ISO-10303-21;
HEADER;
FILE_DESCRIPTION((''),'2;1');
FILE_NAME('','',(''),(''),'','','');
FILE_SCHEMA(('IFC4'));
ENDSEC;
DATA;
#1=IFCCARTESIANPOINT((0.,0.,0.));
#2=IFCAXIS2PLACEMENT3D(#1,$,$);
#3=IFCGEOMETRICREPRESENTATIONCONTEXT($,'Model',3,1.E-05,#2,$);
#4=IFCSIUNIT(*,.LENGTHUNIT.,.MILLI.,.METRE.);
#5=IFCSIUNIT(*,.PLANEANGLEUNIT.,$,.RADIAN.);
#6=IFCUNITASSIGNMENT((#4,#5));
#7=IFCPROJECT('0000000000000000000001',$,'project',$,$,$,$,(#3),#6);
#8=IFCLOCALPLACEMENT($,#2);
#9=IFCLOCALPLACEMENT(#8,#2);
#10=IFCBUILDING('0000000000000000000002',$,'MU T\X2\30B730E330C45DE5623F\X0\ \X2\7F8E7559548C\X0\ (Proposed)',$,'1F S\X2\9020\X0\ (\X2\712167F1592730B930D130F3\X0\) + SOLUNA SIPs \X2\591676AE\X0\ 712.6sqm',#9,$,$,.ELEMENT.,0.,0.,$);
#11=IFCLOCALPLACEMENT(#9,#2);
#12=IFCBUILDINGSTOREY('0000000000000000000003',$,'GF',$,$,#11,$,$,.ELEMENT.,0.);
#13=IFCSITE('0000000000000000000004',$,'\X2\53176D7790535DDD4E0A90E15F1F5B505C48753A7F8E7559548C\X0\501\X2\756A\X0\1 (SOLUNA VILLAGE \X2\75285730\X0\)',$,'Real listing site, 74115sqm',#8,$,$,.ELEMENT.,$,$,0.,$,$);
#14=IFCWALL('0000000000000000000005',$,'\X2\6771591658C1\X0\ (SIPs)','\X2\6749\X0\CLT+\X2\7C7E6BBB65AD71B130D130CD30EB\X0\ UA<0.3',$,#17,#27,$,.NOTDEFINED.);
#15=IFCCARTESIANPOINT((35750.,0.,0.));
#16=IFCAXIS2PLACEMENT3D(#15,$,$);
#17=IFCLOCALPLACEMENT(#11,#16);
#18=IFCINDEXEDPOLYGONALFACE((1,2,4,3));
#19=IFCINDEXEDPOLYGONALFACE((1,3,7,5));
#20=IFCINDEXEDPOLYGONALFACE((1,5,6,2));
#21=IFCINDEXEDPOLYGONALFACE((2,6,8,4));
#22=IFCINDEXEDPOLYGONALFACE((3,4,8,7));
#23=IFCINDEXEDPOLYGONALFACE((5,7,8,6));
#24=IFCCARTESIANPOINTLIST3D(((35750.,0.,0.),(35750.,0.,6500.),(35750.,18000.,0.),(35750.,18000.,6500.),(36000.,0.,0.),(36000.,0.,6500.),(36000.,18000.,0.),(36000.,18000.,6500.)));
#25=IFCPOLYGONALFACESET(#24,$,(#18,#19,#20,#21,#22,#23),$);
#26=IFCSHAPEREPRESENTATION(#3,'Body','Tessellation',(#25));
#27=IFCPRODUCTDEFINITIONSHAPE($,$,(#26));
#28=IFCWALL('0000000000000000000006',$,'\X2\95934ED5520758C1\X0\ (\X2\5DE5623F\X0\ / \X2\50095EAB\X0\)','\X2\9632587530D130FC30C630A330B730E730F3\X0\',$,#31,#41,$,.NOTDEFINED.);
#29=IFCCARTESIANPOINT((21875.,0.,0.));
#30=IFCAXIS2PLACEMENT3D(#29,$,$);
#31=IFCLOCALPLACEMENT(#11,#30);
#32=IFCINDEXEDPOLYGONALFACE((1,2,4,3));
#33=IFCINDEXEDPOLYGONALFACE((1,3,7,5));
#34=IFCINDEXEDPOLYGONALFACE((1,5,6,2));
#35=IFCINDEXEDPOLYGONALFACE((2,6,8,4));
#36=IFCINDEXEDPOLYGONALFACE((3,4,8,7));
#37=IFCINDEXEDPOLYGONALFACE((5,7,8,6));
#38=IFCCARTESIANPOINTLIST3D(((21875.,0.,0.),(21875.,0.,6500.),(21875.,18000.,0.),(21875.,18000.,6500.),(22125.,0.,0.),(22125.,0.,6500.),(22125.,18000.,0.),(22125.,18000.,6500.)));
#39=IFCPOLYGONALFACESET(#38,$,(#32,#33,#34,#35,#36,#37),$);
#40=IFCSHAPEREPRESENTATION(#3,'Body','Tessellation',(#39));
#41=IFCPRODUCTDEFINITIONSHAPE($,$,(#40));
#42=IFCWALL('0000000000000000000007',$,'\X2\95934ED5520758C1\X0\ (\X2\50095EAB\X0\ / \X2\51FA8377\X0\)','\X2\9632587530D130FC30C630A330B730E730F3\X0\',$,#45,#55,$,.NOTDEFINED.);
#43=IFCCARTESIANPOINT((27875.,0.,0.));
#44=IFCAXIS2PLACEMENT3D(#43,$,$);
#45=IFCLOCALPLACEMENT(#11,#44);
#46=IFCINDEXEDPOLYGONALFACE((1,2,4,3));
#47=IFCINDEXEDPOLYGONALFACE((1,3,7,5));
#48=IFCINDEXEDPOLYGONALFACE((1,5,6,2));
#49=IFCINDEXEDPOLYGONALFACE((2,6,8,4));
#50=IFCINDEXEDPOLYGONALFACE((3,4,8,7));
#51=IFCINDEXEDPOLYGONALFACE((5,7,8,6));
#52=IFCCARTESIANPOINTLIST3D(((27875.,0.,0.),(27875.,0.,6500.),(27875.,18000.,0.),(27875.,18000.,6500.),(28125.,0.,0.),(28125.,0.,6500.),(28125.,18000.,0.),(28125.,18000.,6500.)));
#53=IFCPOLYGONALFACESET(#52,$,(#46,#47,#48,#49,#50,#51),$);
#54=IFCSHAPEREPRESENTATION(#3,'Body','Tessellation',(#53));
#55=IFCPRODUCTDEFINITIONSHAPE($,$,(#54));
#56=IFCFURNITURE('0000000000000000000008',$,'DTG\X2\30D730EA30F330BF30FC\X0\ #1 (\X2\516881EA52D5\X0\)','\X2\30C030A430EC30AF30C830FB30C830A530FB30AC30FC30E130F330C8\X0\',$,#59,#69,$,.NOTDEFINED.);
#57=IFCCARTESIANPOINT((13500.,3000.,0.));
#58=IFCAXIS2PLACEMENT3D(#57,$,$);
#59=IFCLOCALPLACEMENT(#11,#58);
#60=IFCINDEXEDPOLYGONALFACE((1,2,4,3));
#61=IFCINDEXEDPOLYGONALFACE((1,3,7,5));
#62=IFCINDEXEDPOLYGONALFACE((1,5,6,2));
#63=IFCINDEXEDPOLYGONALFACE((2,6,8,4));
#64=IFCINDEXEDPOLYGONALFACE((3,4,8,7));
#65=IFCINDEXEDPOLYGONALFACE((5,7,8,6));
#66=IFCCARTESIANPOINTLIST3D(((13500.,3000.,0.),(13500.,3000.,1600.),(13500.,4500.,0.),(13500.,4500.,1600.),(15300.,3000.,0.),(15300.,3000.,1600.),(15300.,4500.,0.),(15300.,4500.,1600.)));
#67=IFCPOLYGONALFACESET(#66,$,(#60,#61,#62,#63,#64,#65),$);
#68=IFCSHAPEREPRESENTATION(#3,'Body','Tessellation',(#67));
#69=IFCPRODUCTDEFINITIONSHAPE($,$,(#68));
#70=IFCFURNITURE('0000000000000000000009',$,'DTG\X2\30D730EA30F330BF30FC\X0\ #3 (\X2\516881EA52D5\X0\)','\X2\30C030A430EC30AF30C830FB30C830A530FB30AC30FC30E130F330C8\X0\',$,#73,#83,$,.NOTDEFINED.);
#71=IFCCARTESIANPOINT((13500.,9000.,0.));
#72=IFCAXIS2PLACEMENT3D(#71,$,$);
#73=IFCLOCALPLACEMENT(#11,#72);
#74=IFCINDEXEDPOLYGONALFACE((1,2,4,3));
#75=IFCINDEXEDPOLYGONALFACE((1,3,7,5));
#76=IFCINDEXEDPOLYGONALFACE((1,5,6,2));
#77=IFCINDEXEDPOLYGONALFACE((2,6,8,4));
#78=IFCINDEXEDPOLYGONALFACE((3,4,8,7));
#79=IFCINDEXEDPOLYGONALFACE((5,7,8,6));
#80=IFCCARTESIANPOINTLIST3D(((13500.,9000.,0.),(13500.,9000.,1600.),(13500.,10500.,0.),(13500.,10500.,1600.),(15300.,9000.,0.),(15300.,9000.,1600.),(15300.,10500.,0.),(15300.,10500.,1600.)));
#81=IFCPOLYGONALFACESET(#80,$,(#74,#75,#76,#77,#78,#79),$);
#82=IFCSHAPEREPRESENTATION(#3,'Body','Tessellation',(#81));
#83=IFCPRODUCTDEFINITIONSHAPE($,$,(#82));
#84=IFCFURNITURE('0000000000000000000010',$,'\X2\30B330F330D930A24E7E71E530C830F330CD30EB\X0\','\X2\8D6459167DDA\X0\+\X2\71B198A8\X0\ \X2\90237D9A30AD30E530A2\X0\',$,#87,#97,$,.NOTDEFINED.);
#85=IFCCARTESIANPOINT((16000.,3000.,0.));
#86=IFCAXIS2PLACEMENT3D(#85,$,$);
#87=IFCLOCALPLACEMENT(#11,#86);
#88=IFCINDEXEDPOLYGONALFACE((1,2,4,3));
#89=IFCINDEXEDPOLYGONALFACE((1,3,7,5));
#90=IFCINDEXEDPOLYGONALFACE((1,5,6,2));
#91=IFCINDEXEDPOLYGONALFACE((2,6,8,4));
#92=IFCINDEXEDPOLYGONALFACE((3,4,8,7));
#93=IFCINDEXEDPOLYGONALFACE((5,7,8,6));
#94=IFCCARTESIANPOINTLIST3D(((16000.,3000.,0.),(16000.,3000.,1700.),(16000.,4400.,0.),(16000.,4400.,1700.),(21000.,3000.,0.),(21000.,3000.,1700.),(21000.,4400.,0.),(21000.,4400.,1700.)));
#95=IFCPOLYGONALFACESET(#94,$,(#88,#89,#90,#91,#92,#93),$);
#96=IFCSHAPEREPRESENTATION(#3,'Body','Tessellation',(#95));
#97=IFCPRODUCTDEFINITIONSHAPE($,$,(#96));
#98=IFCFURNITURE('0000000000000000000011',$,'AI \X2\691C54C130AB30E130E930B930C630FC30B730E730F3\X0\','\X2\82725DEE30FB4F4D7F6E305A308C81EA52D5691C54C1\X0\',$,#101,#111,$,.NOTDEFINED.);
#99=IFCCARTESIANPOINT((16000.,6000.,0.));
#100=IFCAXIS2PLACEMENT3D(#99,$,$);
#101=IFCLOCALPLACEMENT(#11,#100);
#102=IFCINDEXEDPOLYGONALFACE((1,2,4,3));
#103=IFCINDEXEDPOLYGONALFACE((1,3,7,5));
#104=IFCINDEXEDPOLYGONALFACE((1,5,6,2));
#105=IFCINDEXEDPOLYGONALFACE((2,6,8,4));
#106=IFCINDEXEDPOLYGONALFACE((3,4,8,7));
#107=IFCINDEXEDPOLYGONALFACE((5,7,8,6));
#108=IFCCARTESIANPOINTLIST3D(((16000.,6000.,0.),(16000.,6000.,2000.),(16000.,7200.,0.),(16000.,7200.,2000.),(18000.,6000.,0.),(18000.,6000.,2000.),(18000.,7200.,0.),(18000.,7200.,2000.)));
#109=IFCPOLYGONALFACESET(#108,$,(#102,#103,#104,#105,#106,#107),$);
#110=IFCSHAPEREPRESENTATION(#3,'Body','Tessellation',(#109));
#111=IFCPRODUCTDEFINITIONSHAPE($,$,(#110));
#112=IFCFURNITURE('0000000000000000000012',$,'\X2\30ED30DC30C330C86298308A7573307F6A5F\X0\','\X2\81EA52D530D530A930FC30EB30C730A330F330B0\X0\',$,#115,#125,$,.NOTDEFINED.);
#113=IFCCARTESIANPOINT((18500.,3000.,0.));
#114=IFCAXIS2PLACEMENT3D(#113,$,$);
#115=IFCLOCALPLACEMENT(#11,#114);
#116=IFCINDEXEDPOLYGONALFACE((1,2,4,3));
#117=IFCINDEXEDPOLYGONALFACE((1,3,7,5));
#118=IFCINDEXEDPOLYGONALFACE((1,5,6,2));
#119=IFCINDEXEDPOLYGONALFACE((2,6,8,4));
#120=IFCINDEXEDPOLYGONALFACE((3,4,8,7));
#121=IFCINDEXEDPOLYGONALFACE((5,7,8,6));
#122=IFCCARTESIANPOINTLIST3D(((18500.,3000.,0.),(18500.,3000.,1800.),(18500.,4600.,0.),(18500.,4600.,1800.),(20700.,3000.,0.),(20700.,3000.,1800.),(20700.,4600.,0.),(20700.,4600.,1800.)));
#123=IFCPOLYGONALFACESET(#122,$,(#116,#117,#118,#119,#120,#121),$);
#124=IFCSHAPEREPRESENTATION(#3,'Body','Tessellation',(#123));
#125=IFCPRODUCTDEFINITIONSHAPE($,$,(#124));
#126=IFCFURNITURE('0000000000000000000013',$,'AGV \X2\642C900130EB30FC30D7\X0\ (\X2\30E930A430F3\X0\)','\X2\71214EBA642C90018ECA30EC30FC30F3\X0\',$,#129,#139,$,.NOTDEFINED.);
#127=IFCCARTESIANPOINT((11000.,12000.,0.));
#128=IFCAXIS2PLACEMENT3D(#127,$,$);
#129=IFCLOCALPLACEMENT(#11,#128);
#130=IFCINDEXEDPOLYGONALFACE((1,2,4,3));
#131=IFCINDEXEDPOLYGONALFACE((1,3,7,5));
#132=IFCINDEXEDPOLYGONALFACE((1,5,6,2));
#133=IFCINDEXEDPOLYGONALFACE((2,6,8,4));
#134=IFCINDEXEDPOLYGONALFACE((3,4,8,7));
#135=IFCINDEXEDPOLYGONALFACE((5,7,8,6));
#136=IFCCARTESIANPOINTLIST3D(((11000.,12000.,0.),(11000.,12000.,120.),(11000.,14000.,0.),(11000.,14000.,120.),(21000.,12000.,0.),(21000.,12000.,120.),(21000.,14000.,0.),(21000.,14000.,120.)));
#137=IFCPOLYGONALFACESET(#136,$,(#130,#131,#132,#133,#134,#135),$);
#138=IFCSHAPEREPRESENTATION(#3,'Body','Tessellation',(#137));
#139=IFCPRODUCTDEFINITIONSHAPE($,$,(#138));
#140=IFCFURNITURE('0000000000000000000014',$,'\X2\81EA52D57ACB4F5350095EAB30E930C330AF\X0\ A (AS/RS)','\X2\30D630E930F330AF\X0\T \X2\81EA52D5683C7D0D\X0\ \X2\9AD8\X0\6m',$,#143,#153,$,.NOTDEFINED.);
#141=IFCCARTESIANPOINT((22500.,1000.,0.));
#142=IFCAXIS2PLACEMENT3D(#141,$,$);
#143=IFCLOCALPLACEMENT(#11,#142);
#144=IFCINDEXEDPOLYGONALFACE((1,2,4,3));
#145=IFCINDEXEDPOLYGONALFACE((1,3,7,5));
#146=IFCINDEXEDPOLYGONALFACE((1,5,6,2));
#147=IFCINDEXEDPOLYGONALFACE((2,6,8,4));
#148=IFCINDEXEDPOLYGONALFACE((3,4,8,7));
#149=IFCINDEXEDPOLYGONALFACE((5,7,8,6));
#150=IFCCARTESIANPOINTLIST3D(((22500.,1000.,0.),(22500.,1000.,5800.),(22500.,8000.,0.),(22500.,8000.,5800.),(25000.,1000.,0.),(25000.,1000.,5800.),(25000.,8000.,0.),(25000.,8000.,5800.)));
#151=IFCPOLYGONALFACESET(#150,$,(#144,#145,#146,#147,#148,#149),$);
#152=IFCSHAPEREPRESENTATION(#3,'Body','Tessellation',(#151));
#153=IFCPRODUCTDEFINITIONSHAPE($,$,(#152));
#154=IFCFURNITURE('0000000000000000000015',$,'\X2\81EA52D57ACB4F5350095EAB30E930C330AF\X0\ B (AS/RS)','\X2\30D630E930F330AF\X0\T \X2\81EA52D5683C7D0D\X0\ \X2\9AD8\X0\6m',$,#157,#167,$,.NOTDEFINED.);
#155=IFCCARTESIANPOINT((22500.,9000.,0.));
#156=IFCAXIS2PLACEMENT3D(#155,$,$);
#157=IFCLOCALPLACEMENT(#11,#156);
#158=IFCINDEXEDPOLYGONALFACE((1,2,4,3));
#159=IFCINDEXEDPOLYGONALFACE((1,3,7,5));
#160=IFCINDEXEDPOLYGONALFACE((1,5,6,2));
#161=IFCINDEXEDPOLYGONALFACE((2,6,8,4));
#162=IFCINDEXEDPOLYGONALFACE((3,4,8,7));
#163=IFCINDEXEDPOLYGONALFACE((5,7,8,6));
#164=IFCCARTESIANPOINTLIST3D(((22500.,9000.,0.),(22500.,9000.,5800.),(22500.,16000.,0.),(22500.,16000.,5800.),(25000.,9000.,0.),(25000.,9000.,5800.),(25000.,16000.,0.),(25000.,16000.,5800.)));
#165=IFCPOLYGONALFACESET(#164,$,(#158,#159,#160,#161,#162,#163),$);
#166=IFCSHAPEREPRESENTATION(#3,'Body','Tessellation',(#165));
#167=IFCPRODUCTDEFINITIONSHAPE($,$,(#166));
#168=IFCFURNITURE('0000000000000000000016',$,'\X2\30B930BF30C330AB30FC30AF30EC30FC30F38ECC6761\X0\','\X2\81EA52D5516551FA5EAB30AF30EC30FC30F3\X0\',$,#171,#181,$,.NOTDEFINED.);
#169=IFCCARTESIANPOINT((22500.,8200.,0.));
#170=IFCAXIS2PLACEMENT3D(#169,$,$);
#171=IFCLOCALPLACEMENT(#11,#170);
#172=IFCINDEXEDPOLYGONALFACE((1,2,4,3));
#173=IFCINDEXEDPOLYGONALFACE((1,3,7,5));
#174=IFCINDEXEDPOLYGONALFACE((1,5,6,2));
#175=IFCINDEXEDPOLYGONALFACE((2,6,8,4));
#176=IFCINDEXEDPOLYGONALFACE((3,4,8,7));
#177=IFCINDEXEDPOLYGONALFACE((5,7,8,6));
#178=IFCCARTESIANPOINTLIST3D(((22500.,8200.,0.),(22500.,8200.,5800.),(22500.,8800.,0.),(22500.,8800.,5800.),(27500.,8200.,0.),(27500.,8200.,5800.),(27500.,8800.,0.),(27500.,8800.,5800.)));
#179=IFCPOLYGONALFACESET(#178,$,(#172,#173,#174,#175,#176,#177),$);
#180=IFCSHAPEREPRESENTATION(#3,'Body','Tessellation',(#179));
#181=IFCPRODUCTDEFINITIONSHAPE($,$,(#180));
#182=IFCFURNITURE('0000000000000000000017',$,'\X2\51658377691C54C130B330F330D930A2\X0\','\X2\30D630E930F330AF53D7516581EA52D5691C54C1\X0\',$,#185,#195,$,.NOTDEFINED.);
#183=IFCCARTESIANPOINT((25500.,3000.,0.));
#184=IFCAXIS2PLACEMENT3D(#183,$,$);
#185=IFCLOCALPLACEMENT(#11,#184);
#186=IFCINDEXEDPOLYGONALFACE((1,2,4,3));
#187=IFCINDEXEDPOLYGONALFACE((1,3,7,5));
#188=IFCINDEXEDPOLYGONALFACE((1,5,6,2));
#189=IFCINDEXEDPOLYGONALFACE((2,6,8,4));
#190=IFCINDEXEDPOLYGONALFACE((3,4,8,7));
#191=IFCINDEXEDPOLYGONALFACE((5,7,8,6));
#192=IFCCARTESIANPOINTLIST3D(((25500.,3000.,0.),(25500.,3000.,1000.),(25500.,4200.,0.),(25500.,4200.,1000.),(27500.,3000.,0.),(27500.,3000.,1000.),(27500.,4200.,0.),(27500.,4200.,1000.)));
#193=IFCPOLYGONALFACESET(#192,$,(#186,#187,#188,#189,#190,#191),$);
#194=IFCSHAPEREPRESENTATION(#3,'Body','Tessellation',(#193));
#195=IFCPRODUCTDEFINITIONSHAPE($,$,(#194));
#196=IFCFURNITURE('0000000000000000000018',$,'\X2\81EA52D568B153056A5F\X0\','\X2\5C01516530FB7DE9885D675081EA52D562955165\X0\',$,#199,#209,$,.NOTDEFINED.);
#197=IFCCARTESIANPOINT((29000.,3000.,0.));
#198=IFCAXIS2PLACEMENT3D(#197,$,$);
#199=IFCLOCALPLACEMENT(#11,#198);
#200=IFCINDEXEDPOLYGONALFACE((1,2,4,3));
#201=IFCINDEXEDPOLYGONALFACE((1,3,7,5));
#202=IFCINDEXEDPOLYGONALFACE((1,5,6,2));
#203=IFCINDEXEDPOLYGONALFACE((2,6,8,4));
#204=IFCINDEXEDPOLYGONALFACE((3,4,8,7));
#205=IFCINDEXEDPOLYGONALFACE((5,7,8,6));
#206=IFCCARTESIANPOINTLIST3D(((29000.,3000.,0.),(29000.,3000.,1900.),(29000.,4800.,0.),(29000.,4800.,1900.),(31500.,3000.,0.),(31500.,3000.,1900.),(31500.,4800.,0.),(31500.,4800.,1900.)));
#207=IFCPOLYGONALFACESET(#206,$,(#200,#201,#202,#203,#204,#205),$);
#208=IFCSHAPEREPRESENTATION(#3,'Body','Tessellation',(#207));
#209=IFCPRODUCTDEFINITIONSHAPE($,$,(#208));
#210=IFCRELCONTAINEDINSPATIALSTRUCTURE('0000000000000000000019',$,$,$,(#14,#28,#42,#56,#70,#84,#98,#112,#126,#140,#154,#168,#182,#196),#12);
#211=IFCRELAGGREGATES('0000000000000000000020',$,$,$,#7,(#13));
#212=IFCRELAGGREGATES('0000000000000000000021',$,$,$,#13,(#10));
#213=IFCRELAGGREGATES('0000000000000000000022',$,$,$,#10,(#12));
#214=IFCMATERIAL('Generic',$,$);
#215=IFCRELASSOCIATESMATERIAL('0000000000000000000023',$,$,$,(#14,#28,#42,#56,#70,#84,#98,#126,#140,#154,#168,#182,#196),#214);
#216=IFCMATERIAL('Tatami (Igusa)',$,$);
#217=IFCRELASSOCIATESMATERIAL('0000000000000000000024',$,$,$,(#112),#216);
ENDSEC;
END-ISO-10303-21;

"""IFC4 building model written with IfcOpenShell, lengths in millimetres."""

from ifc_helpers import new_model, si_unit, frame, frame_2d, origin, place, context, project, spatial, rectangle, extrude, material, element, save


model = new_model("IFC4")

# Units and contexts
model_context = context("Model", 3, precision=1e-05, world=origin())
ifc_project = project(units=[si_unit("LENGTHUNIT", "METRE", prefix="MILLI"), si_unit("PLANEANGLEUNIT", "RADIAN")], contexts=[model_context])

# Site, building, storey
site_placement = place(None, origin())
site = spatial("IfcSite", under=ifc_project, at=site_placement, Name="北海道川上郡弟子屈町美留和501番1 (SOLUNA VILLAGE 用地)", ObjectType="Real listing site, 74115sqm", CompositionType="ELEMENT", RefElevation=0.0)
building_placement = place(site_placement, origin())
building = spatial("IfcBuilding", under=site, at=building_placement, Name="MU Tシャツ工房 美留和 (Proposed)", ObjectType="1F S造 (無柱大スパン) + SOLUNA SIPs 外皮 712.6sqm", CompositionType="ELEMENT", ElevationOfRefHeight=0.0, ElevationOfTerrain=0.0)
storey_placement = place(building_placement, origin())
storey = spatial("IfcBuildingStorey", under=building, at=storey_placement, Name="GF", CompositionType="ELEMENT", Elevation=0.0)

# Shared definitions
ifc_material_1 = material(Name="Generic")

# Walls
wall_1_placement = place(storey_placement, frame((35750.0, 0.0, 0.0)))
element("IfcWall", 1, at=wall_1_placement, inside=storey, material=ifc_material_1, Name="東外壁 (SIPs)", Description="杉CLT+籾殻断熱パネル UA<0.3", PredefinedType="NOTDEFINED", context=model_context, shape_type="SweptSolid", body=[
    extrude(rectangle(XDim=250.0, YDim=18000.0, at=frame_2d((125.0, 9000.0))), frame((35750.0, 0.0, 0.0)), (0.0, 0.0, 1.0), 6500.0),
])
wall_2_placement = place(storey_placement, frame((21875.0, 0.0, 0.0)))
element("IfcWall", 2, at=wall_2_placement, inside=storey, material=ifc_material_1, Name="間仕切壁 (工房 / 倉庫)", Description="防塵パーティション", PredefinedType="NOTDEFINED", context=model_context, shape_type="SweptSolid", body=[
    extrude(rectangle(XDim=250.0, YDim=18000.0, at=frame_2d((125.0, 9000.0))), frame((21875.0, 0.0, 0.0)), (0.0, 0.0, 1.0), 6500.0),
])
wall_3_placement = place(storey_placement, frame((27875.0, 0.0, 0.0)))
element("IfcWall", 3, at=wall_3_placement, inside=storey, material=ifc_material_1, Name="間仕切壁 (倉庫 / 出荷)", Description="防塵パーティション", PredefinedType="NOTDEFINED", context=model_context, shape_type="SweptSolid", body=[
    extrude(rectangle(XDim=250.0, YDim=18000.0, at=frame_2d((125.0, 9000.0))), frame((27875.0, 0.0, 0.0)), (0.0, 0.0, 1.0), 6500.0),
])

# Furniture
furniture_1_placement = place(storey_placement, frame((13500.0, 3000.0, 0.0)))
element("IfcFurniture", 4, at=furniture_1_placement, inside=storey, material=ifc_material_1, Name="DTGプリンター #1 (全自動)", Description="ダイレクト・トゥ・ガーメント", PredefinedType="NOTDEFINED", context=model_context, shape_type="SweptSolid", body=[
    extrude(rectangle(XDim=1800.0, YDim=1500.0, at=frame_2d((900.0, 750.0))), frame((13500.0, 3000.0, 0.0)), (0.0, 0.0, 1.0), 1600.0),
])
furniture_2_placement = place(storey_placement, frame((13500.0, 9000.0, 0.0)))
element("IfcFurniture", 5, at=furniture_2_placement, inside=storey, material=ifc_material_1, Name="DTGプリンター #3 (全自動)", Description="ダイレクト・トゥ・ガーメント", PredefinedType="NOTDEFINED", context=model_context, shape_type="SweptSolid", body=[
    extrude(rectangle(XDim=1800.0, YDim=1500.0, at=frame_2d((900.0, 750.0))), frame((13500.0, 9000.0, 0.0)), (0.0, 0.0, 1.0), 1600.0),
])
furniture_3_placement = place(storey_placement, frame((16000.0, 3000.0, 0.0)))
element("IfcFurniture", 6, at=furniture_3_placement, inside=storey, material=ifc_material_1, Name="コンベア乾燥トンネル", Description="赤外線+熱風 連続キュア", PredefinedType="NOTDEFINED", context=model_context, shape_type="SweptSolid", body=[
    extrude(rectangle(XDim=5000.0, YDim=1400.0, at=frame_2d((2500.0, 700.0))), frame((16000.0, 3000.0, 0.0)), (0.0, 0.0, 1.0), 1700.0),
])
furniture_4_placement = place(storey_placement, frame((16000.0, 6000.0, 0.0)))
element("IfcFurniture", 7, at=furniture_4_placement, inside=storey, material=ifc_material_1, Name="AI 検品カメラステーション", Description="色差・位置ずれ自動検品", PredefinedType="NOTDEFINED", context=model_context, shape_type="SweptSolid", body=[
    extrude(rectangle(XDim=2000.0, YDim=1200.0, at=frame_2d((1000.0, 600.0))), frame((16000.0, 6000.0, 0.0)), (0.0, 0.0, 1.0), 2000.0),
])
ifc_material_2 = material(Name="Tatami (Igusa)")
furniture_5_placement = place(storey_placement, frame((18500.0, 3000.0, 0.0)))
element("IfcFurniture", 8, at=furniture_5_placement, inside=storey, material=ifc_material_2, Name="ロボット折り畳み機", Description="自動フォールディング", PredefinedType="NOTDEFINED", context=model_context, shape_type="SweptSolid", body=[
    extrude(rectangle(XDim=2200.0, YDim=1600.0, at=frame_2d((1100.0, 800.0))), frame((18500.0, 3000.0, 0.0)), (0.0, 0.0, 1.0), 1800.0),
])
furniture_6_placement = place(storey_placement, frame((11000.0, 12000.0, 0.0)))
element("IfcFurniture", 9, at=furniture_6_placement, inside=storey, material=ifc_material_1, Name="AGV 搬送ループ (ライン)", Description="無人搬送車レーン", PredefinedType="NOTDEFINED", context=model_context, shape_type="SweptSolid", body=[
    extrude(rectangle(XDim=10000.0, YDim=2000.0, at=frame_2d((5000.0, 1000.0))), frame((11000.0, 12000.0, 0.0)), (0.0, 0.0, 1.0), 120.0),
])
furniture_7_placement = place(storey_placement, frame((22500.0, 1000.0, 0.0)))
element("IfcFurniture", 10, at=furniture_7_placement, inside=storey, material=ifc_material_1, Name="自動立体倉庫ラック A (AS/RS)", Description="ブランクT 自動格納 高6m", PredefinedType="NOTDEFINED", context=model_context, shape_type="SweptSolid", body=[
    extrude(rectangle(XDim=2500.0, YDim=7000.0, at=frame_2d((1250.0, 3500.0))), frame((22500.0, 1000.0, 0.0)), (0.0, 0.0, 1.0), 5800.0),
])
furniture_8_placement = place(storey_placement, frame((22500.0, 9000.0, 0.0)))
element("IfcFurniture", 11, at=furniture_8_placement, inside=storey, material=ifc_material_1, Name="自動立体倉庫ラック B (AS/RS)", Description="ブランクT 自動格納 高6m", PredefinedType="NOTDEFINED", context=model_context, shape_type="SweptSolid", body=[
    extrude(rectangle(XDim=2500.0, YDim=7000.0, at=frame_2d((1250.0, 3500.0))), frame((22500.0, 9000.0, 0.0)), (0.0, 0.0, 1.0), 5800.0),
])
furniture_9_placement = place(storey_placement, frame((22500.0, 8200.0, 0.0)))
element("IfcFurniture", 12, at=furniture_9_placement, inside=storey, material=ifc_material_1, Name="スタッカークレーン軌条", Description="自動入出庫クレーン", PredefinedType="NOTDEFINED", context=model_context, shape_type="SweptSolid", body=[
    extrude(rectangle(XDim=5000.0, YDim=600.0, at=frame_2d((2500.0, 300.0))), frame((22500.0, 8200.0, 0.0)), (0.0, 0.0, 1.0), 5800.0),
])
furniture_10_placement = place(storey_placement, frame((25500.0, 3000.0, 0.0)))
element("IfcFurniture", 13, at=furniture_10_placement, inside=storey, material=ifc_material_1, Name="入荷検品コンベア", Description="ブランク受入自動検品", PredefinedType="NOTDEFINED", context=model_context, shape_type="SweptSolid", body=[
    extrude(rectangle(XDim=2000.0, YDim=1200.0, at=frame_2d((1000.0, 600.0))), frame((25500.0, 3000.0, 0.0)), (0.0, 0.0, 1.0), 1000.0),
])
furniture_11_placement = place(storey_placement, frame((29000.0, 3000.0, 0.0)))
element("IfcFurniture", 14, at=furniture_11_placement, inside=storey, material=ifc_material_1, Name="自動梱包機", Description="封入・緩衝材自動投入", PredefinedType="NOTDEFINED", context=model_context, shape_type="SweptSolid", body=[
    extrude(rectangle(XDim=2500.0, YDim=1800.0, at=frame_2d((1250.0, 900.0))), frame((29000.0, 3000.0, 0.0)), (0.0, 0.0, 1.0), 1900.0),
])

save(model, "model.ifc")
